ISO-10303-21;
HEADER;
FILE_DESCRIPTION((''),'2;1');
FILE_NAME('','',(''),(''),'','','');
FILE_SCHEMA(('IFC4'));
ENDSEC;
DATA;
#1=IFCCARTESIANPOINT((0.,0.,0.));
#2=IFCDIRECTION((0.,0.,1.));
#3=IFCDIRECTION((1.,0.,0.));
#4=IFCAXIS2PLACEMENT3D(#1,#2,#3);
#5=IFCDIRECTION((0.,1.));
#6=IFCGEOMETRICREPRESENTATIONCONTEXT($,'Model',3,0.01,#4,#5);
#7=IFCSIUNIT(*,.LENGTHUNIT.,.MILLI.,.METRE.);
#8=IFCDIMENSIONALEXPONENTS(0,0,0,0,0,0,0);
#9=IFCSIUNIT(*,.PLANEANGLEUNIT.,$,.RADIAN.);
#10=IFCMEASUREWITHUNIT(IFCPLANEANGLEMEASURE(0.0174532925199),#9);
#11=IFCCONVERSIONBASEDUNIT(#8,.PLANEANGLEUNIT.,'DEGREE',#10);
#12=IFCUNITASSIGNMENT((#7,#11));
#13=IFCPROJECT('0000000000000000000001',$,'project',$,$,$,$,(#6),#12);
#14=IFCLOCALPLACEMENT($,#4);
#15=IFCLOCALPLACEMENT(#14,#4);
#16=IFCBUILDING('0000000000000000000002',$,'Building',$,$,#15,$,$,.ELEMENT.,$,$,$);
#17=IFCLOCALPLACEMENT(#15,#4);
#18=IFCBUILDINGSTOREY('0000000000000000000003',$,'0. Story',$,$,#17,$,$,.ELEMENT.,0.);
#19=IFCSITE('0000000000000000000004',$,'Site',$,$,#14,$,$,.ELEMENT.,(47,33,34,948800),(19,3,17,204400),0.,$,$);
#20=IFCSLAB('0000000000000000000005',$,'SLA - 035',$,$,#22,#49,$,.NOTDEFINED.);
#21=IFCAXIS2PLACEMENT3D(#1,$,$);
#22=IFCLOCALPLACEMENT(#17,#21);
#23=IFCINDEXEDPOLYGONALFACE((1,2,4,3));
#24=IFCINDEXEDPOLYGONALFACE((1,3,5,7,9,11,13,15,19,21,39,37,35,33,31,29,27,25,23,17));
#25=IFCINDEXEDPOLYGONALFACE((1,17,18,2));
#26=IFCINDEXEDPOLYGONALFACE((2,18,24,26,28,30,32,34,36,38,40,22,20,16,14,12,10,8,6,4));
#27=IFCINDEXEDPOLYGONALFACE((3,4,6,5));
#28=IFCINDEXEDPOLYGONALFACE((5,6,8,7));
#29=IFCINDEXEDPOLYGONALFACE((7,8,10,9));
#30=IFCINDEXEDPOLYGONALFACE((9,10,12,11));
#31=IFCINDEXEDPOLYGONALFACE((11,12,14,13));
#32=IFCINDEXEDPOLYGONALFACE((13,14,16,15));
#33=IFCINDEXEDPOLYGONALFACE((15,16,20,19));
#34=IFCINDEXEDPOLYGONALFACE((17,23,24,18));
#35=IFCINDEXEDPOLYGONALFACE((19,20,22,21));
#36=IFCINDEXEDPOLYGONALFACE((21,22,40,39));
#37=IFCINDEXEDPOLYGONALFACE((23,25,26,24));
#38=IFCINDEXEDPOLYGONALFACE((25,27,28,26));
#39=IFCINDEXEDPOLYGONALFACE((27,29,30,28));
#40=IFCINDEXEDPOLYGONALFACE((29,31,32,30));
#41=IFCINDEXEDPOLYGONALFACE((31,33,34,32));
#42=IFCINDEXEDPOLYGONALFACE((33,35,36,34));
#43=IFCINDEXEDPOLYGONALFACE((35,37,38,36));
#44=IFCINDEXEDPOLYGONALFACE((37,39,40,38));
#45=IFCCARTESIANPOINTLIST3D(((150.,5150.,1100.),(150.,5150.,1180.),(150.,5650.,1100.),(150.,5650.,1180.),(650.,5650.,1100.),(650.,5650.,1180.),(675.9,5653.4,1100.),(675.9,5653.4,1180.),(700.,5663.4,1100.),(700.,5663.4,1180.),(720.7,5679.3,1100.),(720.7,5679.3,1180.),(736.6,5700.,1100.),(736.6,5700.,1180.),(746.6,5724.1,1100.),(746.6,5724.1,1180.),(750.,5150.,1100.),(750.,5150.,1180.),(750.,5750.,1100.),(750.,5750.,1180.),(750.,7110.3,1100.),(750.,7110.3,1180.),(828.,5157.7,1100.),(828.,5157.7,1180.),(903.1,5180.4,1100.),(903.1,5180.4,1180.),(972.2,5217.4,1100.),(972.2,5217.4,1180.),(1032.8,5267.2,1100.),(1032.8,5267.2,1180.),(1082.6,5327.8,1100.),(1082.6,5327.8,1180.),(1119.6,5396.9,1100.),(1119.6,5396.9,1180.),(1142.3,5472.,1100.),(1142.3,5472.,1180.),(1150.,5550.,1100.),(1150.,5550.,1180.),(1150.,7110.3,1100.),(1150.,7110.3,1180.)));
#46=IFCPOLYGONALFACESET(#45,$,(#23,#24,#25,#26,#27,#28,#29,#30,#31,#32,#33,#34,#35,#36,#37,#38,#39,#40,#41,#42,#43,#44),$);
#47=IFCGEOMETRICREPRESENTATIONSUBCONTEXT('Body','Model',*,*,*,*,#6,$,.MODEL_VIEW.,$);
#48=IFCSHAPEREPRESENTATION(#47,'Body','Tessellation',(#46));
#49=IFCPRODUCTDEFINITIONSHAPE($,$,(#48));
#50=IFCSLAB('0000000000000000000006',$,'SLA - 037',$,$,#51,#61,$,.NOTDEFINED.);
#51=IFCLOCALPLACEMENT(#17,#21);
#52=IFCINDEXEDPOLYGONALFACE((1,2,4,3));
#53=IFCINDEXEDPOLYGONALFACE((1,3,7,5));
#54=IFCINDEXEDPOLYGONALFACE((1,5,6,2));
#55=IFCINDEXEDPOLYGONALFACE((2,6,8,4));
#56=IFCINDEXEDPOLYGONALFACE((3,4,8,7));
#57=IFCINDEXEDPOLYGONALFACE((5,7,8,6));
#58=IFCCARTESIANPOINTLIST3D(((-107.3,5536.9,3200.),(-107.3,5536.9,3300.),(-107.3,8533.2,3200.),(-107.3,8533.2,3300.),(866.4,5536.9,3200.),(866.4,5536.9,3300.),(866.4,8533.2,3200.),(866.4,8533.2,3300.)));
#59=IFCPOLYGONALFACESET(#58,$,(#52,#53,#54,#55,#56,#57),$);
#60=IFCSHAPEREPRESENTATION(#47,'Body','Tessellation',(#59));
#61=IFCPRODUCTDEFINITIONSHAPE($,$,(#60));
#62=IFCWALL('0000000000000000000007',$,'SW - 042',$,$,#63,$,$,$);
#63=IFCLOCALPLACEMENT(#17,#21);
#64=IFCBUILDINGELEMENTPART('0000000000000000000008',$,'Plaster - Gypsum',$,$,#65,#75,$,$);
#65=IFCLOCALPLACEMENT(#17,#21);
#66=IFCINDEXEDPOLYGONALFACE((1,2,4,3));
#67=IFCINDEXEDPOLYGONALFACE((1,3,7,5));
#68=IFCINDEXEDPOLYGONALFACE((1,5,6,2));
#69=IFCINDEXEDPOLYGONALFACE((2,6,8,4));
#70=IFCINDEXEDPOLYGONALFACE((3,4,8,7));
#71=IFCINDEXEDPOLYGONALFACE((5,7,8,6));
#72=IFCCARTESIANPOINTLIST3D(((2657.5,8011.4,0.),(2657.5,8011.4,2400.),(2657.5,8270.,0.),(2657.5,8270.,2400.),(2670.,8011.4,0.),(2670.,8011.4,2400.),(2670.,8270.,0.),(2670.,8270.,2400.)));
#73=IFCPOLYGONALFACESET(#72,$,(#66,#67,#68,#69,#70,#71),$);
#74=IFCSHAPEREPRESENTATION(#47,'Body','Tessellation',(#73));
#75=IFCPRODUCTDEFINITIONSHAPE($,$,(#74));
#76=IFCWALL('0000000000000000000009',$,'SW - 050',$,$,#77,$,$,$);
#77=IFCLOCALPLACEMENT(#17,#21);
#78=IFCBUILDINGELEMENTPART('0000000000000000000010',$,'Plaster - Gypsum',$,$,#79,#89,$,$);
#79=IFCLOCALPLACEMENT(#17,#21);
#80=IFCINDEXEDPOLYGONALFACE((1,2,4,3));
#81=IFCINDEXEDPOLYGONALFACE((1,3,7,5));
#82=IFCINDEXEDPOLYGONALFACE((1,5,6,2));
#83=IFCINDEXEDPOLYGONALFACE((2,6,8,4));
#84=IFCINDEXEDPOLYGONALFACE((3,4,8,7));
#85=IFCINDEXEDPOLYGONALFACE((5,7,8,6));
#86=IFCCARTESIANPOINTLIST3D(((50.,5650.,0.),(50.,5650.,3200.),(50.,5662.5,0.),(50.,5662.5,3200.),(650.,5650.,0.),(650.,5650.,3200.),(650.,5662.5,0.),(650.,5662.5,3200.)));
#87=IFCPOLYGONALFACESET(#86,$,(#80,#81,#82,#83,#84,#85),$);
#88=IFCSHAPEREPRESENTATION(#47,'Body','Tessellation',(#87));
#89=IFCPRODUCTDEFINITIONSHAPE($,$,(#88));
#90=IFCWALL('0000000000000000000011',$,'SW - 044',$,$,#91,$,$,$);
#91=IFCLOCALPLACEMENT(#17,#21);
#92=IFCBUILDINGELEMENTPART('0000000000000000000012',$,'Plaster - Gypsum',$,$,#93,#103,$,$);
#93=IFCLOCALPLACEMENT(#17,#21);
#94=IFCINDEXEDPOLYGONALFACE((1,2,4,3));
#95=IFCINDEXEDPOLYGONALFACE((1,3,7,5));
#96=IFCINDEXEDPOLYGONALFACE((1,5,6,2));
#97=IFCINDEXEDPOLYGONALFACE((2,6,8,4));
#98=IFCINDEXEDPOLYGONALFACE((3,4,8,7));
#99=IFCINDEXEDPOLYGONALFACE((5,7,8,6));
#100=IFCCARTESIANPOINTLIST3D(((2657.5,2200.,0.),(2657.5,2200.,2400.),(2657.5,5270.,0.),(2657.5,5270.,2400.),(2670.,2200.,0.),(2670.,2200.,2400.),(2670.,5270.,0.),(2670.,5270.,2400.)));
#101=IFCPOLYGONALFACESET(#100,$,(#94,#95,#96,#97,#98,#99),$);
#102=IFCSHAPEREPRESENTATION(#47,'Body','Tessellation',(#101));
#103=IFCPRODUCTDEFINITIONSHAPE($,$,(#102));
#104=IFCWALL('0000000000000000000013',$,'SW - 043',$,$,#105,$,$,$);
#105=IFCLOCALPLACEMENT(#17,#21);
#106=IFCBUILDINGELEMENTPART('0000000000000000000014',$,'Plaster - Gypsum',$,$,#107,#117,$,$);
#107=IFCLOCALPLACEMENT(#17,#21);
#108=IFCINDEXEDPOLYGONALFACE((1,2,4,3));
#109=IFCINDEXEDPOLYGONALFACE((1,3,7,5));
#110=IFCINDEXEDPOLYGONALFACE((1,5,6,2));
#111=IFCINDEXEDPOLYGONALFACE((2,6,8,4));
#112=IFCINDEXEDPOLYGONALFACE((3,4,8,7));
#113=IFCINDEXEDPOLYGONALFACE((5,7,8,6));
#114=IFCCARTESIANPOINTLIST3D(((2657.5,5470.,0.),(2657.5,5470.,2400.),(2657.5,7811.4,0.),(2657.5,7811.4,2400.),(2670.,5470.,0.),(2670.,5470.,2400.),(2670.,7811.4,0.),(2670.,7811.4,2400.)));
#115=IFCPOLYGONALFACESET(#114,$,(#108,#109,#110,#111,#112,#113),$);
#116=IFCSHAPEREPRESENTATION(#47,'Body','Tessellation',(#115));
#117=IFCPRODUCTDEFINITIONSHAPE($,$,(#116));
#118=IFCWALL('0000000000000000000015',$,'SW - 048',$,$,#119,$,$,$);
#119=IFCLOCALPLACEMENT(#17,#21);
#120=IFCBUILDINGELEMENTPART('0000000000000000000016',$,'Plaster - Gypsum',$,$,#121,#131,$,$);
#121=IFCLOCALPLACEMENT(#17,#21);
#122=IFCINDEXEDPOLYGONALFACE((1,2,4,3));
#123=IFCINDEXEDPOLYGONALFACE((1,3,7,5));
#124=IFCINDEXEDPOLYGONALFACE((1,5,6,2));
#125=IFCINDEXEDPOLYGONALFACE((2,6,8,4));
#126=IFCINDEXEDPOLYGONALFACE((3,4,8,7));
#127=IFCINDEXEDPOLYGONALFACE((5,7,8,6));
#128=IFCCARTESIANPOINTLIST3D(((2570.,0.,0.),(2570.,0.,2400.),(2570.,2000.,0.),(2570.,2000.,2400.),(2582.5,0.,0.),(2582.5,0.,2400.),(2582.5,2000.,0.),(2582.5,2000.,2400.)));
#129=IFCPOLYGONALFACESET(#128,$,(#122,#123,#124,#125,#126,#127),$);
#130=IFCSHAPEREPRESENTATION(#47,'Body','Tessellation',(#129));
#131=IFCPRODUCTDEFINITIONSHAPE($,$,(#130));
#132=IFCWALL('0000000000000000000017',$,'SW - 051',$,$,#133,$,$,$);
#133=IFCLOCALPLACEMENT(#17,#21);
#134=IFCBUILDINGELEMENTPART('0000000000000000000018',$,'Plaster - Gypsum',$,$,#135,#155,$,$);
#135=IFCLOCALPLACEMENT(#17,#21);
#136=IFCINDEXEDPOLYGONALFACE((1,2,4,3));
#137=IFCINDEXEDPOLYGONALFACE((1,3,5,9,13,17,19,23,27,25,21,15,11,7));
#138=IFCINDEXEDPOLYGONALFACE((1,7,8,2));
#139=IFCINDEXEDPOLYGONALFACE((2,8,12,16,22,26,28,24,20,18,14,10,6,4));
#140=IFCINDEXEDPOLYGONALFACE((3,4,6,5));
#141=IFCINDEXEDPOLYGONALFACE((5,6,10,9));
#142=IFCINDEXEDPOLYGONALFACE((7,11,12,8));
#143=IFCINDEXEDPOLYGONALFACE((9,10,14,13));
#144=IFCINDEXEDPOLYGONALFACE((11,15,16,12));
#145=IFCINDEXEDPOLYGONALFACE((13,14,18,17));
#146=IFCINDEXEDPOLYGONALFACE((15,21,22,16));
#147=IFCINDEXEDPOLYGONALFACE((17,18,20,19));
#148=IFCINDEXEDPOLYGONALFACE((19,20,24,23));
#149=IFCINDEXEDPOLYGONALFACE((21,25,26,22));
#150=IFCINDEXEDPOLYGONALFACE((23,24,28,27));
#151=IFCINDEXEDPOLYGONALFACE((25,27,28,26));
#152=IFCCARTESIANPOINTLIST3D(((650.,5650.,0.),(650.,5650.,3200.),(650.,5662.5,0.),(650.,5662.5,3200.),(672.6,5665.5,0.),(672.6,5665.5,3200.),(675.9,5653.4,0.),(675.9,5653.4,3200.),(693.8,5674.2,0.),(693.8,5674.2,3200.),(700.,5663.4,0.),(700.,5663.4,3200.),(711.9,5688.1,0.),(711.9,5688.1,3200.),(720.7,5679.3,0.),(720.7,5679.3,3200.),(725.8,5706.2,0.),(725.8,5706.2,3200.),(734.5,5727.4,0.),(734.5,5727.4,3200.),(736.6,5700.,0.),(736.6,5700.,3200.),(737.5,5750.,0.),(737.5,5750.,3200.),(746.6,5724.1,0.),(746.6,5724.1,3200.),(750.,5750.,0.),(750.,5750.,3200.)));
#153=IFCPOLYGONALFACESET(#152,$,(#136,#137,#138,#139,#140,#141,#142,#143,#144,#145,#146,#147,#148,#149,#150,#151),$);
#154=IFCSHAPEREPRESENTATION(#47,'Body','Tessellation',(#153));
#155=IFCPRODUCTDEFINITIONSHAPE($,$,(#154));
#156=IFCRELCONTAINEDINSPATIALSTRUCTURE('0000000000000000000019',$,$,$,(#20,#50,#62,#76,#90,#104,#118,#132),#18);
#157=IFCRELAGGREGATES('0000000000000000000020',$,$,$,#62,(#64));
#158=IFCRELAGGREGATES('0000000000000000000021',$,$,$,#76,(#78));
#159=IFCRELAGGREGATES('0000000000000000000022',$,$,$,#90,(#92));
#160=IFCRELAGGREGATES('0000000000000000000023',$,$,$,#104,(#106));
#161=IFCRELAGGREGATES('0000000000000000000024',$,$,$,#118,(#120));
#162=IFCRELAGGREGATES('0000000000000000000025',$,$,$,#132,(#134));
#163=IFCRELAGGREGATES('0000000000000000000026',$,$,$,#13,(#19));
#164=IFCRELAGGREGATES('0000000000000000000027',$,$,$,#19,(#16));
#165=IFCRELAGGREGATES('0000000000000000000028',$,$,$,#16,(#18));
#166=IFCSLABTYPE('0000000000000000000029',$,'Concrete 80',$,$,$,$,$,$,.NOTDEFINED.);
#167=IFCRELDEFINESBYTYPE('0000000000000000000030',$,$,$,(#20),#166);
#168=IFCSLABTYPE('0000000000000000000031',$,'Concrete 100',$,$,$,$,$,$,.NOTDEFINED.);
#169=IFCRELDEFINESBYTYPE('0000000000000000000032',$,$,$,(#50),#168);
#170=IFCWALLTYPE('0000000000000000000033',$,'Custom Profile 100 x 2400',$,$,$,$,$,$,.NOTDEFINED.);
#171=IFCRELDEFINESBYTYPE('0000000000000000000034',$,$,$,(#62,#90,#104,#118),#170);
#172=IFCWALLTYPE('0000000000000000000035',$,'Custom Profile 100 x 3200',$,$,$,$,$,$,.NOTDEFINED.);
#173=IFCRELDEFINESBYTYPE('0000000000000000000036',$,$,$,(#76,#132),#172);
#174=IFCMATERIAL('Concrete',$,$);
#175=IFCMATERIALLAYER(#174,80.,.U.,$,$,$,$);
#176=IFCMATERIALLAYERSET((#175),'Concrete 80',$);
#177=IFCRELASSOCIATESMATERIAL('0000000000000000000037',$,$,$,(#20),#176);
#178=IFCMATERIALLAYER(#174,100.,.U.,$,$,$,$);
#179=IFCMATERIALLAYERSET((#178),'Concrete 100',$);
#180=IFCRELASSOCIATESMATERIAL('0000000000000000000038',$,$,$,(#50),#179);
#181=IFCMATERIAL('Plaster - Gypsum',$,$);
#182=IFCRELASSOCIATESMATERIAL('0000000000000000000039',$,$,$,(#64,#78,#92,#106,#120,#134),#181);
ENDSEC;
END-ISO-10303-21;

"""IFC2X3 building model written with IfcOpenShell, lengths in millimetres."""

from ifc_helpers import new_model, entity, si_unit, converted_unit, point, direction, frame, frame_2d, origin_with_axes, place, context, subcontext, project, spatial, polyline, circle_curve, parameter, trimmed, segment, composite_curve, outline, extrude, material, layer, layer_set, layer_usage, type_object, element, aggregate, save


model = new_model("IFC2X3")

# Units and contexts
model_context = context("Model", 3, precision=0.01, world=origin_with_axes(), true_north=direction((0.0, 1.0)))
body_context = subcontext(model_context, "Body", "Model", "MODEL_VIEW")
ifc_project = project(units=[si_unit("LENGTHUNIT", "METRE", prefix="MILLI"), converted_unit("PLANEANGLEUNIT", "DEGREE", entity("IfcPlaneAngleMeasure", 0.0174532925199), si_unit("PLANEANGLEUNIT", "RADIAN"), dimensions=[0, 0, 0, 0, 0, 0, 0])], contexts=[model_context])

# Site, building, storey
site_placement = place(None, origin_with_axes())
site = spatial("IfcSite", under=ifc_project, at=site_placement, Name="Site", CompositionType="ELEMENT", RefLatitude=(47, 33, 34, 948800), RefLongitude=(19, 3, 17, 204400), RefElevation=0.0)
building_placement = place(site_placement, origin_with_axes())
building = spatial("IfcBuilding", under=site, at=building_placement, Name="Building", CompositionType="ELEMENT")
storey_placement = place(building_placement, origin_with_axes())
storey = spatial("IfcBuildingStorey", under=building, at=storey_placement, Name="0. Story", CompositionType="ELEMENT", Elevation=0.0)

# Shared definitions
ifc_material_1 = material(Name="Concrete")

# Slabs
ifc_layer_1 = layer(ifc_material_1, 80.0, ventilated="UNKNOWN")
ifc_layer_set_1 = layer_set([ifc_layer_1], Name="Concrete 80")
ifc_layer_usage_1 = layer_usage(ifc_layer_set_1, "AXIS3", "NEGATIVE", 80.0)
slab_type_1 = type_object("IfcSlabType", Name="Concrete 80", PredefinedType="NOTDEFINED")
slab_1_placement = place(storey_placement, frame((750.0, 7110.3, 1100.0), z_axis=(0.0, 0.0, 1.0), x_axis=(1.0, 0.0, 0.0)))
element("IfcSlab", 1, at=slab_1_placement, inside=storey, type_object=slab_type_1, material=ifc_layer_usage_1, Name="SLA - 035", PredefinedType="NOTDEFINED", context=body_context, shape_type="SweptSolid", body=[
    extrude(outline(composite_curve([segment(polyline([(0.0, 0.0), (0.0, -1360.3)]), True, "CONTINUOUS"), segment(trimmed(circle_curve(frame_2d((-100.0, -1360.3), x_axis=(0.0, -1.0)), 100.0), [point((0.0, -1360.3)), parameter(90.0)], [point((-100.0, -1460.3)), parameter(0.0)], False, "CARTESIAN"), True, "CONTINUOUS"), segment(polyline([(-100.0, -1460.3), (-600.0, -1460.3), (-600.0, -1960.3), (0.0, -1960.3)]), True, "CONTINUOUS"), segment(trimmed(circle_curve(frame_2d((0.0, -1560.3), x_axis=(0.0, -1.0)), 400.0), [point((0.0, -1960.3)), parameter(0.0)], [point((400.0, -1560.3)), parameter(90.0)], True, "CARTESIAN"), True, "CONTINUOUS"), segment(polyline([(400.0, -1560.3), (400.0, 0.0), (0.0, 0.0)]), True, "CONTINUOUS")], self_intersect=False)), origin_with_axes(), (0.0, 0.0, 1.0), 80.0),
])
ifc_layer_2 = layer(ifc_material_1, 100.0, ventilated="UNKNOWN")
ifc_layer_set_2 = layer_set([ifc_layer_2], Name="Concrete 100")
ifc_layer_usage_2 = layer_usage(ifc_layer_set_2, "AXIS3", "NEGATIVE", 100.0)
slab_type_2 = type_object("IfcSlabType", Name="Concrete 100", PredefinedType="NOTDEFINED")
slab_2_placement = place(storey_placement, frame((-107.3, 5536.9, 3200.0), z_axis=(0.0, 0.0, 1.0), x_axis=(1.0, 0.0, 0.0)))
element("IfcSlab", 2, at=slab_2_placement, inside=storey, type_object=slab_type_2, material=ifc_layer_usage_2, Name="SLA - 037", PredefinedType="NOTDEFINED", context=body_context, shape_type="SweptSolid", body=[
    extrude(outline(polyline([(0.0, 0.0), (973.7, 0.0), (973.7, 2996.3), (0.0, 2996.3), (0.0, 0.0)])), origin_with_axes(), (0.0, 0.0, 1.0), 100.0),
])

# Walls, building element parts
wall_type_1 = type_object("IfcWallType", Name="Custom Profile 100 x 2400", PredefinedType="NOTDEFINED")
wall_1_placement = place(storey_placement, frame((2670.0, 8011.4, 0.0), z_axis=(0.0, 0.0, 1.0), x_axis=(0.0, 1.0, 0.0)))
wall_1 = element("IfcWall", 3, at=wall_1_placement, inside=storey, type_object=wall_type_1, Name="SW - 042")
ifc_material_2 = material(Name="Plaster - Gypsum")
building_element_part_1_placement = place(wall_1_placement, origin_with_axes())
building_element_part_1 = element("IfcBuildingElementPart", 4, at=building_element_part_1_placement, material=ifc_material_2, Name="Plaster - Gypsum", context=body_context, shape_type="SweptSolid", body=[
    extrude(outline(polyline([(-12.5, 2400.0), (-12.5, 0.0), (0.0, 0.0), (0.0, 2400.0), (-12.5, 2400.0)])), frame((0.0, 0.0, 0.0), z_axis=(-1.0, 0.0, 0.0), x_axis=(0.0, -1.0, 0.0)), (0.0, 0.0, -1.0), 258.6),
])
aggregate(wall_1, [building_element_part_1])
wall_type_2 = type_object("IfcWallType", Name="Custom Profile 100 x 3200", PredefinedType="NOTDEFINED")
wall_2_placement = place(storey_placement, frame((50.0, 5650.0, 0.0), z_axis=(0.0, 0.0, 1.0), x_axis=(1.0, 0.0, 0.0)))
wall_2 = element("IfcWall", 5, at=wall_2_placement, inside=storey, type_object=wall_type_2, Name="SW - 050")
building_element_part_2_placement = place(wall_2_placement, origin_with_axes())
building_element_part_2 = element("IfcBuildingElementPart", 6, at=building_element_part_2_placement, material=ifc_material_2, Name="Plaster - Gypsum", context=body_context, shape_type="SweptSolid", body=[
    extrude(outline(polyline([(-12.5, 3200.0), (-12.5, 0.0), (0.0, 0.0), (0.0, 3200.0), (-12.5, 3200.0)])), frame((0.0, 0.0, 0.0), z_axis=(-1.0, 0.0, 0.0), x_axis=(0.0, -1.0, 0.0)), (0.0, 0.0, -1.0), 600.0),
])
aggregate(wall_2, [building_element_part_2])
wall_3_placement = place(storey_placement, frame((2670.0, 2200.0, 0.0), z_axis=(0.0, 0.0, 1.0), x_axis=(0.0, 1.0, 0.0)))
wall_3 = element("IfcWall", 7, at=wall_3_placement, inside=storey, type_object=wall_type_1, Name="SW - 044")
building_element_part_3_placement = place(wall_3_placement, origin_with_axes())
building_element_part_3 = element("IfcBuildingElementPart", 8, at=building_element_part_3_placement, material=ifc_material_2, Name="Plaster - Gypsum", context=body_context, shape_type="SweptSolid", body=[
    extrude(outline(polyline([(-12.5, 2400.0), (-12.5, 0.0), (0.0, 0.0), (0.0, 2400.0), (-12.5, 2400.0)])), frame((0.0, 0.0, 0.0), z_axis=(-1.0, 0.0, 0.0), x_axis=(0.0, -1.0, 0.0)), (0.0, 0.0, -1.0), 3070.0),
])
aggregate(wall_3, [building_element_part_3])
wall_4_placement = place(storey_placement, frame((2670.0, 5470.0, 0.0), z_axis=(0.0, 0.0, 1.0), x_axis=(0.0, 1.0, 0.0)))
wall_4 = element("IfcWall", 9, at=wall_4_placement, inside=storey, type_object=wall_type_1, Name="SW - 043")
building_element_part_4_placement = place(wall_4_placement, origin_with_axes())
building_element_part_4 = element("IfcBuildingElementPart", 10, at=building_element_part_4_placement, material=ifc_material_2, Name="Plaster - Gypsum", context=body_context, shape_type="SweptSolid", body=[
    extrude(outline(polyline([(-12.5, 2400.0), (-12.5, 0.0), (0.0, 0.0), (0.0, 2400.0), (-12.5, 2400.0)])), frame((0.0, 0.0, 0.0), z_axis=(-1.0, 0.0, 0.0), x_axis=(0.0, -1.0, 0.0)), (0.0, 0.0, -1.0), 2341.4),
])
aggregate(wall_4, [building_element_part_4])
wall_5_placement = place(storey_placement, frame((2570.0, 2000.0, 0.0), z_axis=(0.0, 0.0, 1.0), x_axis=(0.0, -1.0, 0.0)))
wall_5 = element("IfcWall", 11, at=wall_5_placement, inside=storey, type_object=wall_type_1, Name="SW - 048")
building_element_part_5_placement = place(wall_5_placement, origin_with_axes())
building_element_part_5 = element("IfcBuildingElementPart", 12, at=building_element_part_5_placement, material=ifc_material_2, Name="Plaster - Gypsum", context=body_context, shape_type="SweptSolid", body=[
    extrude(outline(polyline([(-12.5, 2400.0), (-12.5, 0.0), (0.0, 0.0), (0.0, 2400.0), (-12.5, 2400.0)])), frame((0.0, 0.0, 0.0), z_axis=(-1.0, 0.0, 0.0), x_axis=(0.0, -1.0, 0.0)), (0.0, 0.0, -1.0), 2000.0),
])
aggregate(wall_5, [building_element_part_5])
wall_6_placement = place(storey_placement, frame((650.0, 5650.0, 0.0), z_axis=(0.0, 0.0, 1.0), x_axis=(1.0, 0.0, 0.0)))
wall_6 = element("IfcWall", 13, at=wall_6_placement, inside=storey, type_object=wall_type_2, Name="SW - 051")
building_element_part_6_placement = place(wall_6_placement, origin_with_axes())
cartesian_point_1 = entity("IfcCartesianPoint", [-12.5, 3200.0])
building_element_part_6 = element("IfcBuildingElementPart", 14, at=building_element_part_6_placement, material=ifc_material_2, Name="Plaster - Gypsum", context=body_context, shape_type="SweptSolid", body=[
    entity("IfcRevolvedAreaSolid", entity("IfcArbitraryClosedProfileDef", "AREA", None, entity("IfcPolyline", [cartesian_point_1, entity("IfcCartesianPoint", [-12.5, 0.0]), entity("IfcCartesianPoint", [0.0, 0.0]), entity("IfcCartesianPoint", [0.0, 3200.0]), cartesian_point_1])), entity("IfcAxis2Placement3D", entity("IfcCartesianPoint", [0.0, 0.0, 0.0]), entity("IfcDirection", [-1.0, 0.0, 0.0]), entity("IfcDirection", [0.0, -1.0, 0.0])), entity("IfcAxis1Placement", entity("IfcCartesianPoint", [-100.0, 0.0, 0.0]), entity("IfcDirection", [0.0, 1.0, 0.0])), 90.0),
])
aggregate(wall_6, [building_element_part_6])

save(model, "model.ifc")
